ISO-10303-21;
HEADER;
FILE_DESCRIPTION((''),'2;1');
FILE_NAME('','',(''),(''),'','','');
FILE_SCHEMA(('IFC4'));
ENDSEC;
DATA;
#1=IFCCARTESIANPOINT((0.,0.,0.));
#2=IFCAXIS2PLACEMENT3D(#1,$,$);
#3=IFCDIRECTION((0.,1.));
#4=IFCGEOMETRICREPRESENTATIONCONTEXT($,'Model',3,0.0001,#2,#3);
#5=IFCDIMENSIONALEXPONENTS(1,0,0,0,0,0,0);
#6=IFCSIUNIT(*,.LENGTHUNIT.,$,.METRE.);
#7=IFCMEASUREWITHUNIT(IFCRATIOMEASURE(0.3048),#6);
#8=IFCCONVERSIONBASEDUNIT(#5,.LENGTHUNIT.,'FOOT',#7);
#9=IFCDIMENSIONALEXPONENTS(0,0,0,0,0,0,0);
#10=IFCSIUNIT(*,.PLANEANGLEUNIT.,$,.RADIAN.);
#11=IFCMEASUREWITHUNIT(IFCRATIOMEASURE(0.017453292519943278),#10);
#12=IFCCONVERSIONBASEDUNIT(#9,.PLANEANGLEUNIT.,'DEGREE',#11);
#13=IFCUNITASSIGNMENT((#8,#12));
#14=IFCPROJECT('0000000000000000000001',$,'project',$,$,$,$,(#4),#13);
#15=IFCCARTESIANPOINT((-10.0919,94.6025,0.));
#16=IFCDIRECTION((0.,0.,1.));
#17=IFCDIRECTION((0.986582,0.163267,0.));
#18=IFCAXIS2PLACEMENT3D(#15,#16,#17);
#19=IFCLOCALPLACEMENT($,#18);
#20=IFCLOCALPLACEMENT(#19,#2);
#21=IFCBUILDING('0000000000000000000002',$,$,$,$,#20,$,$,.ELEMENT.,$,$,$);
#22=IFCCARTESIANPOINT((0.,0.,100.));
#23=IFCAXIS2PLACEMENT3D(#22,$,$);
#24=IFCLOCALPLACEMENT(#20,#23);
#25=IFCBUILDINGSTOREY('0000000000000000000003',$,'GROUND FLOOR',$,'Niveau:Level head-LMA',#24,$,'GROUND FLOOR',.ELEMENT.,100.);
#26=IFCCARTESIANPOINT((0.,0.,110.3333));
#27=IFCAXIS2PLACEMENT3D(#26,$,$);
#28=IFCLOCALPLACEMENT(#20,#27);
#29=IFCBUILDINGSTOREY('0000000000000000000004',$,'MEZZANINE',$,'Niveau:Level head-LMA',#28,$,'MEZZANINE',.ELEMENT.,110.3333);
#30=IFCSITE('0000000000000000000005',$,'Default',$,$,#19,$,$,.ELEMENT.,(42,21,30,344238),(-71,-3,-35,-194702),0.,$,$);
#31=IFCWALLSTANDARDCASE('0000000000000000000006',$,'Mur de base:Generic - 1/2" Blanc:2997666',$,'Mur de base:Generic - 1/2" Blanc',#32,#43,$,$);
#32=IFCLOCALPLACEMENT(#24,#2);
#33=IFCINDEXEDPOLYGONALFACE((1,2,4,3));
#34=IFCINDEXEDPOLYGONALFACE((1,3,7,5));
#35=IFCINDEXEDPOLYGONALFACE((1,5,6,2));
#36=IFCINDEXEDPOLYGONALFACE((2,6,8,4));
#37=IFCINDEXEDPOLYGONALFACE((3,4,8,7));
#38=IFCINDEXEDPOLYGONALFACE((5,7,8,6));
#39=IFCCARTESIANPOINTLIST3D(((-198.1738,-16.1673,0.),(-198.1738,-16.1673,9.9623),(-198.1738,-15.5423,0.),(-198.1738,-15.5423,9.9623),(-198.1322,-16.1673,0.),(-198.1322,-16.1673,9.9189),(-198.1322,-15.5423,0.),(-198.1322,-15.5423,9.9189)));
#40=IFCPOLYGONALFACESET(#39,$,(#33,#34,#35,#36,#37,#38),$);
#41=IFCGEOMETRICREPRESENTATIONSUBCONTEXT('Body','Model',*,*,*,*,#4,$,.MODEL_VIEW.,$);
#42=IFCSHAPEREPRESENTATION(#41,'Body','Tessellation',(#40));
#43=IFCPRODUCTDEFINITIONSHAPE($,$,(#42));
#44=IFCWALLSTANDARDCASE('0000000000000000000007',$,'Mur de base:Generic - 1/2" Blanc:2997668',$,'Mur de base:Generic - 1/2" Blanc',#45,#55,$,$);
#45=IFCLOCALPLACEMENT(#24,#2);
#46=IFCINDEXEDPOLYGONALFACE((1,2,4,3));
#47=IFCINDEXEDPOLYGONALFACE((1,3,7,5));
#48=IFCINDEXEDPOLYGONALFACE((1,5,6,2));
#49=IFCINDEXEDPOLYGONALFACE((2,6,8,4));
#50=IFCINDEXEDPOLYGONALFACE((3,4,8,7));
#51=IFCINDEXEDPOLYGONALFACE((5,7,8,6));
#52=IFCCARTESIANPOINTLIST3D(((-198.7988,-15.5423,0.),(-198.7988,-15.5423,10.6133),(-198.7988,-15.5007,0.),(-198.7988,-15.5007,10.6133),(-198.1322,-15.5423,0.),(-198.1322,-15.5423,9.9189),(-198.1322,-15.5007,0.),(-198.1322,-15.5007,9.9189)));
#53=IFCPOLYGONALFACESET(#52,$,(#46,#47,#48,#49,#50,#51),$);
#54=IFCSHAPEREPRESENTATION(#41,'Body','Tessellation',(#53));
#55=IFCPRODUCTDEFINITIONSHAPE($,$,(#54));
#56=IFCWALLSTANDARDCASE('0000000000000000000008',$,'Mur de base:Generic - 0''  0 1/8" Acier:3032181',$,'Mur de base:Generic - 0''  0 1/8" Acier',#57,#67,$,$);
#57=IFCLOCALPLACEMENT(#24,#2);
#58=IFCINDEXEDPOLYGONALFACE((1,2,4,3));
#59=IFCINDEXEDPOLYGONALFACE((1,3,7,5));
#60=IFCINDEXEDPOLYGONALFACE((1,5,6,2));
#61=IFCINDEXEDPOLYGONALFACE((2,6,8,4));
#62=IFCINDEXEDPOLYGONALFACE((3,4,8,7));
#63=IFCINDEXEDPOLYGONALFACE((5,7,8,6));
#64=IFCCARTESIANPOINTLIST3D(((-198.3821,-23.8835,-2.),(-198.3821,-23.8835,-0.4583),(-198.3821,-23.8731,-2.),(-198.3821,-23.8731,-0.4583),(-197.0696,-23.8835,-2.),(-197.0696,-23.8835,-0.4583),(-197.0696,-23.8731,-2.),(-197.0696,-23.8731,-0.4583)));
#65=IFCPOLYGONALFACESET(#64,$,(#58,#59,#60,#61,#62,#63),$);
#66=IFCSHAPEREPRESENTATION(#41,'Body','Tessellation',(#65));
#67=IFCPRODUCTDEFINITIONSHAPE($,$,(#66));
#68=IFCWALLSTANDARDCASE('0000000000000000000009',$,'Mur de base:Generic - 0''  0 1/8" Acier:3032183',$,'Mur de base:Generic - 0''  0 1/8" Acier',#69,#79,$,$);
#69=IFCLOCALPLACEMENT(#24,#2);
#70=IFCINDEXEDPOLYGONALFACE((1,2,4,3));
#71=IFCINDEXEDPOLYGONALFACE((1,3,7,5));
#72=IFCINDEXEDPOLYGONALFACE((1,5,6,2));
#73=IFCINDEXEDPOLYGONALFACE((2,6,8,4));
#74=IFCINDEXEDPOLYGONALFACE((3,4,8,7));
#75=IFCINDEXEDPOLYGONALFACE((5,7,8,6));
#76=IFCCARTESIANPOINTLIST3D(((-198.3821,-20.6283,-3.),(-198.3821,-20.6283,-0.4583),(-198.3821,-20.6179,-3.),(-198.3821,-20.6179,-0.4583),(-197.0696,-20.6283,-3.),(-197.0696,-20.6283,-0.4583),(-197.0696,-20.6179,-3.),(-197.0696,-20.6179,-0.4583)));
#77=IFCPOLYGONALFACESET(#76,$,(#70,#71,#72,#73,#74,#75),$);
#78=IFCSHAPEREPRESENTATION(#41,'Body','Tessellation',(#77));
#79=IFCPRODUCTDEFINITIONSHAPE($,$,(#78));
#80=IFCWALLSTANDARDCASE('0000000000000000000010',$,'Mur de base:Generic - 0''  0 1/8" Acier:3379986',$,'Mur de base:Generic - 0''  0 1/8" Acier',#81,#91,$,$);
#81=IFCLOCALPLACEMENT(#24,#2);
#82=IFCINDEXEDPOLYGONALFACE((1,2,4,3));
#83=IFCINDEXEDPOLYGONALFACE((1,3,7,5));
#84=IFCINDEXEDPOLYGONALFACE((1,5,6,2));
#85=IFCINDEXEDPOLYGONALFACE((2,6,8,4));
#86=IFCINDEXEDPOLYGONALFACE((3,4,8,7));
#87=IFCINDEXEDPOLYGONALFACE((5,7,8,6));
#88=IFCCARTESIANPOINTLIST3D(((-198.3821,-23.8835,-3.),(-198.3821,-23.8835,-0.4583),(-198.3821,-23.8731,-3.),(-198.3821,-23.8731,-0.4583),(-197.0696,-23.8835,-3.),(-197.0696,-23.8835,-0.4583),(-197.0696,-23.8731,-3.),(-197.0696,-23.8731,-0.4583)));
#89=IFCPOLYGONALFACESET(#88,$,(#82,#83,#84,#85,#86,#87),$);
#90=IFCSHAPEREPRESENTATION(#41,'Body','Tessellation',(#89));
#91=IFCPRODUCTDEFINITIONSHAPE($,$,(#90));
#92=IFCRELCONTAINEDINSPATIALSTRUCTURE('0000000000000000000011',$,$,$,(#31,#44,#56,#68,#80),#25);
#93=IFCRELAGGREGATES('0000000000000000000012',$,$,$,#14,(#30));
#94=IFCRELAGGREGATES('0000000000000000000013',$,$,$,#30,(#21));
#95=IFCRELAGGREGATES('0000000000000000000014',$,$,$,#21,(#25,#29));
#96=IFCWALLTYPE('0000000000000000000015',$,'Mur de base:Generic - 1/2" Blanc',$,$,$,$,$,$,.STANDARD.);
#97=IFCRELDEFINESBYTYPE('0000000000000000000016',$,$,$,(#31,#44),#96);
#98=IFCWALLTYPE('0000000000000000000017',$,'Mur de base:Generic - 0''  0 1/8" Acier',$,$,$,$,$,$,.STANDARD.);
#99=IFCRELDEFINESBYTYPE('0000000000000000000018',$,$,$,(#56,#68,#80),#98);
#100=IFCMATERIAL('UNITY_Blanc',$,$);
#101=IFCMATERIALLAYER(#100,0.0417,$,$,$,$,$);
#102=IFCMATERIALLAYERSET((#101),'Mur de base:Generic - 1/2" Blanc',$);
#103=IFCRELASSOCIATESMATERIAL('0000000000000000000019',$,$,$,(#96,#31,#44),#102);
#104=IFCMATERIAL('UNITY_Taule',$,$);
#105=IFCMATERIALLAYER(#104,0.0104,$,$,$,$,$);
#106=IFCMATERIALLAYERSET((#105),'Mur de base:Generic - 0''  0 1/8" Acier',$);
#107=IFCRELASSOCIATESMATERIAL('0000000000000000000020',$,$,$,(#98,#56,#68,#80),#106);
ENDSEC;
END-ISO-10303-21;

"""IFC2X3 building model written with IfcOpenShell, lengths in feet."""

from ifc_helpers import new_model, entity, si_unit, converted_unit, direction, frame, frame_2d, origin, place, context, subcontext, project, spatial, polyline, rectangle, extrude, clip, bounded_halfspace, material, layer, layer_set, layer_usage, type_object, element, save


model = new_model("IFC2X3")

# Units and contexts
model_context = context("Model", 3, precision=0.0001, world=origin(), true_north=direction((0.0, 1.0)))
body_context = subcontext(model_context, "Body", "Model", "MODEL_VIEW")
ifc_project = project(units=[converted_unit("LENGTHUNIT", "FOOT", entity("IfcRatioMeasure", 0.3048), si_unit("LENGTHUNIT", "METRE"), dimensions=[1, 0, 0, 0, 0, 0, 0]), converted_unit("PLANEANGLEUNIT", "DEGREE", entity("IfcRatioMeasure", 0.017453292519943278), si_unit("PLANEANGLEUNIT", "RADIAN"), dimensions=[0, 0, 0, 0, 0, 0, 0])], contexts=[model_context])

# Site, building, storey
site_placement = place(None, frame((-10.0919, 94.6025, 0.0), z_axis=(0.0, 0.0, 1.0), x_axis=(0.986582, 0.163267, 0.0)))
site = spatial("IfcSite", under=ifc_project, at=site_placement, Name="Default", CompositionType="ELEMENT", RefLatitude=(42, 21, 30, 344238), RefLongitude=(-71, -3, -35, -194702), RefElevation=0.0)
building_placement = place(site_placement, origin())
building = spatial("IfcBuilding", under=site, at=building_placement, CompositionType="ELEMENT")
storey_1_placement = place(building_placement, frame((0.0, 0.0, 100.0)))
storey_1 = spatial("IfcBuildingStorey", under=building, at=storey_1_placement, Name="GROUND FLOOR", ObjectType="Niveau:Level head-LMA", LongName="GROUND FLOOR", CompositionType="ELEMENT", Elevation=100.0)

# Shared definitions
storey_2_placement = place(building_placement, frame((0.0, 0.0, 110.3333)))
storey_2 = spatial("IfcBuildingStorey", under=building, at=storey_2_placement, Name="MEZZANINE", ObjectType="Niveau:Level head-LMA", LongName="MEZZANINE", CompositionType="ELEMENT", Elevation=110.3333)

# Walls
ifc_material_1 = material(Name="UNITY_Blanc")
ifc_layer_1 = layer(ifc_material_1, 0.0417)
ifc_layer_set_1 = layer_set([ifc_layer_1], Name="Mur de base:Generic - 1/2\" Blanc")
ifc_layer_usage_1 = layer_usage(ifc_layer_set_1, "AXIS2", "POSITIVE", -0.0208)
wall_type_1 = type_object("IfcWallType", Name="Mur de base:Generic - 1/2\" Blanc", PredefinedType="STANDARD", material=ifc_layer_set_1)
wall_1_placement = place(storey_1_placement, frame((-198.153, -16.1673, 0.0), z_axis=(0.0, 0.0, 1.0), x_axis=(0.0, 1.0, 0.0)))
element("IfcWallStandardCase", 1, at=wall_1_placement, inside=storey_1, type_object=wall_type_1, material=ifc_layer_usage_1, Name="Mur de base:Generic - 1/2\" Blanc:2997666", ObjectType="Mur de base:Generic - 1/2\" Blanc", context=body_context, shape_type="Clipping", body=[
    clip(extrude(rectangle(XDim=0.625, YDim=0.0417, at=frame_2d((0.3125, 0.0), x_axis=(-1.0, 0.0))), origin(), (0.0, 0.0, 1.0), 9.9623), bounded_halfspace(frame((0.0, -0.0208, 9.9189), z_axis=(0.0, -0.721387, 0.692532), x_axis=(1.0, 0.0, 0.0)), False, frame((0.0, -0.0208, 9.9189)), polyline([(0.0, 0.0), (0.625, 0.0), (0.625, 0.0417), (0.0, 0.0417), (0.0, 0.0)]))),
])
ifc_layer_usage_2 = layer_usage(ifc_layer_set_1, "AXIS2", "POSITIVE", -0.0208)
wall_2_placement = place(storey_1_placement, frame((-198.1322, -15.5215, 0.0), z_axis=(0.0, 0.0, 1.0), x_axis=(-1.0, 0.0, 0.0)))
element("IfcWallStandardCase", 2, at=wall_2_placement, inside=storey_1, type_object=wall_type_1, material=ifc_layer_usage_2, Name="Mur de base:Generic - 1/2\" Blanc:2997668", ObjectType="Mur de base:Generic - 1/2\" Blanc", context=body_context, shape_type="Clipping", body=[
    clip(extrude(rectangle(XDim=0.6667, YDim=0.0417, at=frame_2d((0.3333, 0.0), x_axis=(-1.0, 0.0))), origin(), (0.0, 0.0, 1.0), 10.6133), bounded_halfspace(frame((0.0, -0.0208, 9.9189), z_axis=(-0.721387, 0.0, 0.692532), x_axis=(0.0, -1.0, 0.0)), False, frame((0.0, -0.0208, 9.9189)), polyline([(0.0, 0.0), (0.6667, 0.0), (0.6667, 0.0417), (0.0417, 0.0417), (0.0, 0.0417), (0.0, 0.0)]))),
])
ifc_material_2 = material(Name="UNITY_Taule")
ifc_layer_2 = layer(ifc_material_2, 0.0104)
ifc_layer_set_2 = layer_set([ifc_layer_2], Name="Mur de base:Generic - 0'  0 1/8\" Acier")
wall_type_2 = type_object("IfcWallType", Name="Mur de base:Generic - 0'  0 1/8\" Acier", PredefinedType="STANDARD", material=ifc_layer_set_2)
ifc_layer_usage_3 = layer_usage(ifc_layer_set_2, "AXIS2", "NEGATIVE", 0.0052)
wall_3_placement = place(storey_1_placement, frame((-198.3821, -23.8783, -2.0)))
element("IfcWallStandardCase", 3, at=wall_3_placement, inside=storey_1, type_object=wall_type_2, material=ifc_layer_usage_3, Name="Mur de base:Generic - 0'  0 1/8\" Acier:3032181", ObjectType="Mur de base:Generic - 0'  0 1/8\" Acier", context=body_context, shape_type="SweptSolid", body=[
    extrude(rectangle(XDim=1.3126, YDim=0.0104, at=frame_2d((0.6563, 0.0), x_axis=(-1.0, 0.0))), origin(), (0.0, 0.0, 1.0), 1.5417),
])
ifc_layer_usage_4 = layer_usage(ifc_layer_set_2, "AXIS2", "POSITIVE", -0.0052)
wall_4_placement = place(storey_1_placement, frame((-198.3821, -20.6231, -3.0)))
element("IfcWallStandardCase", 4, at=wall_4_placement, inside=storey_1, type_object=wall_type_2, material=ifc_layer_usage_4, Name="Mur de base:Generic - 0'  0 1/8\" Acier:3032183", ObjectType="Mur de base:Generic - 0'  0 1/8\" Acier", context=body_context, shape_type="SweptSolid", body=[
    extrude(rectangle(XDim=1.3126, YDim=0.0104, at=frame_2d((0.6563, 0.0), x_axis=(-1.0, 0.0))), origin(), (0.0, 0.0, 1.0), 2.5417),
])
ifc_layer_usage_5 = layer_usage(ifc_layer_set_2, "AXIS2", "NEGATIVE", 0.0052)
wall_5_placement = place(storey_1_placement, frame((-198.3821, -23.8783, -3.0)))
element("IfcWallStandardCase", 5, at=wall_5_placement, inside=storey_1, type_object=wall_type_2, material=ifc_layer_usage_5, Name="Mur de base:Generic - 0'  0 1/8\" Acier:3379986", ObjectType="Mur de base:Generic - 0'  0 1/8\" Acier", context=body_context, shape_type="SweptSolid", body=[
    extrude(rectangle(XDim=1.3126, YDim=0.0104, at=frame_2d((0.6563, 0.0), x_axis=(-1.0, 0.0))), origin(), (0.0, 0.0, 1.0), 2.5417),
])

save(model, "model.ifc")
